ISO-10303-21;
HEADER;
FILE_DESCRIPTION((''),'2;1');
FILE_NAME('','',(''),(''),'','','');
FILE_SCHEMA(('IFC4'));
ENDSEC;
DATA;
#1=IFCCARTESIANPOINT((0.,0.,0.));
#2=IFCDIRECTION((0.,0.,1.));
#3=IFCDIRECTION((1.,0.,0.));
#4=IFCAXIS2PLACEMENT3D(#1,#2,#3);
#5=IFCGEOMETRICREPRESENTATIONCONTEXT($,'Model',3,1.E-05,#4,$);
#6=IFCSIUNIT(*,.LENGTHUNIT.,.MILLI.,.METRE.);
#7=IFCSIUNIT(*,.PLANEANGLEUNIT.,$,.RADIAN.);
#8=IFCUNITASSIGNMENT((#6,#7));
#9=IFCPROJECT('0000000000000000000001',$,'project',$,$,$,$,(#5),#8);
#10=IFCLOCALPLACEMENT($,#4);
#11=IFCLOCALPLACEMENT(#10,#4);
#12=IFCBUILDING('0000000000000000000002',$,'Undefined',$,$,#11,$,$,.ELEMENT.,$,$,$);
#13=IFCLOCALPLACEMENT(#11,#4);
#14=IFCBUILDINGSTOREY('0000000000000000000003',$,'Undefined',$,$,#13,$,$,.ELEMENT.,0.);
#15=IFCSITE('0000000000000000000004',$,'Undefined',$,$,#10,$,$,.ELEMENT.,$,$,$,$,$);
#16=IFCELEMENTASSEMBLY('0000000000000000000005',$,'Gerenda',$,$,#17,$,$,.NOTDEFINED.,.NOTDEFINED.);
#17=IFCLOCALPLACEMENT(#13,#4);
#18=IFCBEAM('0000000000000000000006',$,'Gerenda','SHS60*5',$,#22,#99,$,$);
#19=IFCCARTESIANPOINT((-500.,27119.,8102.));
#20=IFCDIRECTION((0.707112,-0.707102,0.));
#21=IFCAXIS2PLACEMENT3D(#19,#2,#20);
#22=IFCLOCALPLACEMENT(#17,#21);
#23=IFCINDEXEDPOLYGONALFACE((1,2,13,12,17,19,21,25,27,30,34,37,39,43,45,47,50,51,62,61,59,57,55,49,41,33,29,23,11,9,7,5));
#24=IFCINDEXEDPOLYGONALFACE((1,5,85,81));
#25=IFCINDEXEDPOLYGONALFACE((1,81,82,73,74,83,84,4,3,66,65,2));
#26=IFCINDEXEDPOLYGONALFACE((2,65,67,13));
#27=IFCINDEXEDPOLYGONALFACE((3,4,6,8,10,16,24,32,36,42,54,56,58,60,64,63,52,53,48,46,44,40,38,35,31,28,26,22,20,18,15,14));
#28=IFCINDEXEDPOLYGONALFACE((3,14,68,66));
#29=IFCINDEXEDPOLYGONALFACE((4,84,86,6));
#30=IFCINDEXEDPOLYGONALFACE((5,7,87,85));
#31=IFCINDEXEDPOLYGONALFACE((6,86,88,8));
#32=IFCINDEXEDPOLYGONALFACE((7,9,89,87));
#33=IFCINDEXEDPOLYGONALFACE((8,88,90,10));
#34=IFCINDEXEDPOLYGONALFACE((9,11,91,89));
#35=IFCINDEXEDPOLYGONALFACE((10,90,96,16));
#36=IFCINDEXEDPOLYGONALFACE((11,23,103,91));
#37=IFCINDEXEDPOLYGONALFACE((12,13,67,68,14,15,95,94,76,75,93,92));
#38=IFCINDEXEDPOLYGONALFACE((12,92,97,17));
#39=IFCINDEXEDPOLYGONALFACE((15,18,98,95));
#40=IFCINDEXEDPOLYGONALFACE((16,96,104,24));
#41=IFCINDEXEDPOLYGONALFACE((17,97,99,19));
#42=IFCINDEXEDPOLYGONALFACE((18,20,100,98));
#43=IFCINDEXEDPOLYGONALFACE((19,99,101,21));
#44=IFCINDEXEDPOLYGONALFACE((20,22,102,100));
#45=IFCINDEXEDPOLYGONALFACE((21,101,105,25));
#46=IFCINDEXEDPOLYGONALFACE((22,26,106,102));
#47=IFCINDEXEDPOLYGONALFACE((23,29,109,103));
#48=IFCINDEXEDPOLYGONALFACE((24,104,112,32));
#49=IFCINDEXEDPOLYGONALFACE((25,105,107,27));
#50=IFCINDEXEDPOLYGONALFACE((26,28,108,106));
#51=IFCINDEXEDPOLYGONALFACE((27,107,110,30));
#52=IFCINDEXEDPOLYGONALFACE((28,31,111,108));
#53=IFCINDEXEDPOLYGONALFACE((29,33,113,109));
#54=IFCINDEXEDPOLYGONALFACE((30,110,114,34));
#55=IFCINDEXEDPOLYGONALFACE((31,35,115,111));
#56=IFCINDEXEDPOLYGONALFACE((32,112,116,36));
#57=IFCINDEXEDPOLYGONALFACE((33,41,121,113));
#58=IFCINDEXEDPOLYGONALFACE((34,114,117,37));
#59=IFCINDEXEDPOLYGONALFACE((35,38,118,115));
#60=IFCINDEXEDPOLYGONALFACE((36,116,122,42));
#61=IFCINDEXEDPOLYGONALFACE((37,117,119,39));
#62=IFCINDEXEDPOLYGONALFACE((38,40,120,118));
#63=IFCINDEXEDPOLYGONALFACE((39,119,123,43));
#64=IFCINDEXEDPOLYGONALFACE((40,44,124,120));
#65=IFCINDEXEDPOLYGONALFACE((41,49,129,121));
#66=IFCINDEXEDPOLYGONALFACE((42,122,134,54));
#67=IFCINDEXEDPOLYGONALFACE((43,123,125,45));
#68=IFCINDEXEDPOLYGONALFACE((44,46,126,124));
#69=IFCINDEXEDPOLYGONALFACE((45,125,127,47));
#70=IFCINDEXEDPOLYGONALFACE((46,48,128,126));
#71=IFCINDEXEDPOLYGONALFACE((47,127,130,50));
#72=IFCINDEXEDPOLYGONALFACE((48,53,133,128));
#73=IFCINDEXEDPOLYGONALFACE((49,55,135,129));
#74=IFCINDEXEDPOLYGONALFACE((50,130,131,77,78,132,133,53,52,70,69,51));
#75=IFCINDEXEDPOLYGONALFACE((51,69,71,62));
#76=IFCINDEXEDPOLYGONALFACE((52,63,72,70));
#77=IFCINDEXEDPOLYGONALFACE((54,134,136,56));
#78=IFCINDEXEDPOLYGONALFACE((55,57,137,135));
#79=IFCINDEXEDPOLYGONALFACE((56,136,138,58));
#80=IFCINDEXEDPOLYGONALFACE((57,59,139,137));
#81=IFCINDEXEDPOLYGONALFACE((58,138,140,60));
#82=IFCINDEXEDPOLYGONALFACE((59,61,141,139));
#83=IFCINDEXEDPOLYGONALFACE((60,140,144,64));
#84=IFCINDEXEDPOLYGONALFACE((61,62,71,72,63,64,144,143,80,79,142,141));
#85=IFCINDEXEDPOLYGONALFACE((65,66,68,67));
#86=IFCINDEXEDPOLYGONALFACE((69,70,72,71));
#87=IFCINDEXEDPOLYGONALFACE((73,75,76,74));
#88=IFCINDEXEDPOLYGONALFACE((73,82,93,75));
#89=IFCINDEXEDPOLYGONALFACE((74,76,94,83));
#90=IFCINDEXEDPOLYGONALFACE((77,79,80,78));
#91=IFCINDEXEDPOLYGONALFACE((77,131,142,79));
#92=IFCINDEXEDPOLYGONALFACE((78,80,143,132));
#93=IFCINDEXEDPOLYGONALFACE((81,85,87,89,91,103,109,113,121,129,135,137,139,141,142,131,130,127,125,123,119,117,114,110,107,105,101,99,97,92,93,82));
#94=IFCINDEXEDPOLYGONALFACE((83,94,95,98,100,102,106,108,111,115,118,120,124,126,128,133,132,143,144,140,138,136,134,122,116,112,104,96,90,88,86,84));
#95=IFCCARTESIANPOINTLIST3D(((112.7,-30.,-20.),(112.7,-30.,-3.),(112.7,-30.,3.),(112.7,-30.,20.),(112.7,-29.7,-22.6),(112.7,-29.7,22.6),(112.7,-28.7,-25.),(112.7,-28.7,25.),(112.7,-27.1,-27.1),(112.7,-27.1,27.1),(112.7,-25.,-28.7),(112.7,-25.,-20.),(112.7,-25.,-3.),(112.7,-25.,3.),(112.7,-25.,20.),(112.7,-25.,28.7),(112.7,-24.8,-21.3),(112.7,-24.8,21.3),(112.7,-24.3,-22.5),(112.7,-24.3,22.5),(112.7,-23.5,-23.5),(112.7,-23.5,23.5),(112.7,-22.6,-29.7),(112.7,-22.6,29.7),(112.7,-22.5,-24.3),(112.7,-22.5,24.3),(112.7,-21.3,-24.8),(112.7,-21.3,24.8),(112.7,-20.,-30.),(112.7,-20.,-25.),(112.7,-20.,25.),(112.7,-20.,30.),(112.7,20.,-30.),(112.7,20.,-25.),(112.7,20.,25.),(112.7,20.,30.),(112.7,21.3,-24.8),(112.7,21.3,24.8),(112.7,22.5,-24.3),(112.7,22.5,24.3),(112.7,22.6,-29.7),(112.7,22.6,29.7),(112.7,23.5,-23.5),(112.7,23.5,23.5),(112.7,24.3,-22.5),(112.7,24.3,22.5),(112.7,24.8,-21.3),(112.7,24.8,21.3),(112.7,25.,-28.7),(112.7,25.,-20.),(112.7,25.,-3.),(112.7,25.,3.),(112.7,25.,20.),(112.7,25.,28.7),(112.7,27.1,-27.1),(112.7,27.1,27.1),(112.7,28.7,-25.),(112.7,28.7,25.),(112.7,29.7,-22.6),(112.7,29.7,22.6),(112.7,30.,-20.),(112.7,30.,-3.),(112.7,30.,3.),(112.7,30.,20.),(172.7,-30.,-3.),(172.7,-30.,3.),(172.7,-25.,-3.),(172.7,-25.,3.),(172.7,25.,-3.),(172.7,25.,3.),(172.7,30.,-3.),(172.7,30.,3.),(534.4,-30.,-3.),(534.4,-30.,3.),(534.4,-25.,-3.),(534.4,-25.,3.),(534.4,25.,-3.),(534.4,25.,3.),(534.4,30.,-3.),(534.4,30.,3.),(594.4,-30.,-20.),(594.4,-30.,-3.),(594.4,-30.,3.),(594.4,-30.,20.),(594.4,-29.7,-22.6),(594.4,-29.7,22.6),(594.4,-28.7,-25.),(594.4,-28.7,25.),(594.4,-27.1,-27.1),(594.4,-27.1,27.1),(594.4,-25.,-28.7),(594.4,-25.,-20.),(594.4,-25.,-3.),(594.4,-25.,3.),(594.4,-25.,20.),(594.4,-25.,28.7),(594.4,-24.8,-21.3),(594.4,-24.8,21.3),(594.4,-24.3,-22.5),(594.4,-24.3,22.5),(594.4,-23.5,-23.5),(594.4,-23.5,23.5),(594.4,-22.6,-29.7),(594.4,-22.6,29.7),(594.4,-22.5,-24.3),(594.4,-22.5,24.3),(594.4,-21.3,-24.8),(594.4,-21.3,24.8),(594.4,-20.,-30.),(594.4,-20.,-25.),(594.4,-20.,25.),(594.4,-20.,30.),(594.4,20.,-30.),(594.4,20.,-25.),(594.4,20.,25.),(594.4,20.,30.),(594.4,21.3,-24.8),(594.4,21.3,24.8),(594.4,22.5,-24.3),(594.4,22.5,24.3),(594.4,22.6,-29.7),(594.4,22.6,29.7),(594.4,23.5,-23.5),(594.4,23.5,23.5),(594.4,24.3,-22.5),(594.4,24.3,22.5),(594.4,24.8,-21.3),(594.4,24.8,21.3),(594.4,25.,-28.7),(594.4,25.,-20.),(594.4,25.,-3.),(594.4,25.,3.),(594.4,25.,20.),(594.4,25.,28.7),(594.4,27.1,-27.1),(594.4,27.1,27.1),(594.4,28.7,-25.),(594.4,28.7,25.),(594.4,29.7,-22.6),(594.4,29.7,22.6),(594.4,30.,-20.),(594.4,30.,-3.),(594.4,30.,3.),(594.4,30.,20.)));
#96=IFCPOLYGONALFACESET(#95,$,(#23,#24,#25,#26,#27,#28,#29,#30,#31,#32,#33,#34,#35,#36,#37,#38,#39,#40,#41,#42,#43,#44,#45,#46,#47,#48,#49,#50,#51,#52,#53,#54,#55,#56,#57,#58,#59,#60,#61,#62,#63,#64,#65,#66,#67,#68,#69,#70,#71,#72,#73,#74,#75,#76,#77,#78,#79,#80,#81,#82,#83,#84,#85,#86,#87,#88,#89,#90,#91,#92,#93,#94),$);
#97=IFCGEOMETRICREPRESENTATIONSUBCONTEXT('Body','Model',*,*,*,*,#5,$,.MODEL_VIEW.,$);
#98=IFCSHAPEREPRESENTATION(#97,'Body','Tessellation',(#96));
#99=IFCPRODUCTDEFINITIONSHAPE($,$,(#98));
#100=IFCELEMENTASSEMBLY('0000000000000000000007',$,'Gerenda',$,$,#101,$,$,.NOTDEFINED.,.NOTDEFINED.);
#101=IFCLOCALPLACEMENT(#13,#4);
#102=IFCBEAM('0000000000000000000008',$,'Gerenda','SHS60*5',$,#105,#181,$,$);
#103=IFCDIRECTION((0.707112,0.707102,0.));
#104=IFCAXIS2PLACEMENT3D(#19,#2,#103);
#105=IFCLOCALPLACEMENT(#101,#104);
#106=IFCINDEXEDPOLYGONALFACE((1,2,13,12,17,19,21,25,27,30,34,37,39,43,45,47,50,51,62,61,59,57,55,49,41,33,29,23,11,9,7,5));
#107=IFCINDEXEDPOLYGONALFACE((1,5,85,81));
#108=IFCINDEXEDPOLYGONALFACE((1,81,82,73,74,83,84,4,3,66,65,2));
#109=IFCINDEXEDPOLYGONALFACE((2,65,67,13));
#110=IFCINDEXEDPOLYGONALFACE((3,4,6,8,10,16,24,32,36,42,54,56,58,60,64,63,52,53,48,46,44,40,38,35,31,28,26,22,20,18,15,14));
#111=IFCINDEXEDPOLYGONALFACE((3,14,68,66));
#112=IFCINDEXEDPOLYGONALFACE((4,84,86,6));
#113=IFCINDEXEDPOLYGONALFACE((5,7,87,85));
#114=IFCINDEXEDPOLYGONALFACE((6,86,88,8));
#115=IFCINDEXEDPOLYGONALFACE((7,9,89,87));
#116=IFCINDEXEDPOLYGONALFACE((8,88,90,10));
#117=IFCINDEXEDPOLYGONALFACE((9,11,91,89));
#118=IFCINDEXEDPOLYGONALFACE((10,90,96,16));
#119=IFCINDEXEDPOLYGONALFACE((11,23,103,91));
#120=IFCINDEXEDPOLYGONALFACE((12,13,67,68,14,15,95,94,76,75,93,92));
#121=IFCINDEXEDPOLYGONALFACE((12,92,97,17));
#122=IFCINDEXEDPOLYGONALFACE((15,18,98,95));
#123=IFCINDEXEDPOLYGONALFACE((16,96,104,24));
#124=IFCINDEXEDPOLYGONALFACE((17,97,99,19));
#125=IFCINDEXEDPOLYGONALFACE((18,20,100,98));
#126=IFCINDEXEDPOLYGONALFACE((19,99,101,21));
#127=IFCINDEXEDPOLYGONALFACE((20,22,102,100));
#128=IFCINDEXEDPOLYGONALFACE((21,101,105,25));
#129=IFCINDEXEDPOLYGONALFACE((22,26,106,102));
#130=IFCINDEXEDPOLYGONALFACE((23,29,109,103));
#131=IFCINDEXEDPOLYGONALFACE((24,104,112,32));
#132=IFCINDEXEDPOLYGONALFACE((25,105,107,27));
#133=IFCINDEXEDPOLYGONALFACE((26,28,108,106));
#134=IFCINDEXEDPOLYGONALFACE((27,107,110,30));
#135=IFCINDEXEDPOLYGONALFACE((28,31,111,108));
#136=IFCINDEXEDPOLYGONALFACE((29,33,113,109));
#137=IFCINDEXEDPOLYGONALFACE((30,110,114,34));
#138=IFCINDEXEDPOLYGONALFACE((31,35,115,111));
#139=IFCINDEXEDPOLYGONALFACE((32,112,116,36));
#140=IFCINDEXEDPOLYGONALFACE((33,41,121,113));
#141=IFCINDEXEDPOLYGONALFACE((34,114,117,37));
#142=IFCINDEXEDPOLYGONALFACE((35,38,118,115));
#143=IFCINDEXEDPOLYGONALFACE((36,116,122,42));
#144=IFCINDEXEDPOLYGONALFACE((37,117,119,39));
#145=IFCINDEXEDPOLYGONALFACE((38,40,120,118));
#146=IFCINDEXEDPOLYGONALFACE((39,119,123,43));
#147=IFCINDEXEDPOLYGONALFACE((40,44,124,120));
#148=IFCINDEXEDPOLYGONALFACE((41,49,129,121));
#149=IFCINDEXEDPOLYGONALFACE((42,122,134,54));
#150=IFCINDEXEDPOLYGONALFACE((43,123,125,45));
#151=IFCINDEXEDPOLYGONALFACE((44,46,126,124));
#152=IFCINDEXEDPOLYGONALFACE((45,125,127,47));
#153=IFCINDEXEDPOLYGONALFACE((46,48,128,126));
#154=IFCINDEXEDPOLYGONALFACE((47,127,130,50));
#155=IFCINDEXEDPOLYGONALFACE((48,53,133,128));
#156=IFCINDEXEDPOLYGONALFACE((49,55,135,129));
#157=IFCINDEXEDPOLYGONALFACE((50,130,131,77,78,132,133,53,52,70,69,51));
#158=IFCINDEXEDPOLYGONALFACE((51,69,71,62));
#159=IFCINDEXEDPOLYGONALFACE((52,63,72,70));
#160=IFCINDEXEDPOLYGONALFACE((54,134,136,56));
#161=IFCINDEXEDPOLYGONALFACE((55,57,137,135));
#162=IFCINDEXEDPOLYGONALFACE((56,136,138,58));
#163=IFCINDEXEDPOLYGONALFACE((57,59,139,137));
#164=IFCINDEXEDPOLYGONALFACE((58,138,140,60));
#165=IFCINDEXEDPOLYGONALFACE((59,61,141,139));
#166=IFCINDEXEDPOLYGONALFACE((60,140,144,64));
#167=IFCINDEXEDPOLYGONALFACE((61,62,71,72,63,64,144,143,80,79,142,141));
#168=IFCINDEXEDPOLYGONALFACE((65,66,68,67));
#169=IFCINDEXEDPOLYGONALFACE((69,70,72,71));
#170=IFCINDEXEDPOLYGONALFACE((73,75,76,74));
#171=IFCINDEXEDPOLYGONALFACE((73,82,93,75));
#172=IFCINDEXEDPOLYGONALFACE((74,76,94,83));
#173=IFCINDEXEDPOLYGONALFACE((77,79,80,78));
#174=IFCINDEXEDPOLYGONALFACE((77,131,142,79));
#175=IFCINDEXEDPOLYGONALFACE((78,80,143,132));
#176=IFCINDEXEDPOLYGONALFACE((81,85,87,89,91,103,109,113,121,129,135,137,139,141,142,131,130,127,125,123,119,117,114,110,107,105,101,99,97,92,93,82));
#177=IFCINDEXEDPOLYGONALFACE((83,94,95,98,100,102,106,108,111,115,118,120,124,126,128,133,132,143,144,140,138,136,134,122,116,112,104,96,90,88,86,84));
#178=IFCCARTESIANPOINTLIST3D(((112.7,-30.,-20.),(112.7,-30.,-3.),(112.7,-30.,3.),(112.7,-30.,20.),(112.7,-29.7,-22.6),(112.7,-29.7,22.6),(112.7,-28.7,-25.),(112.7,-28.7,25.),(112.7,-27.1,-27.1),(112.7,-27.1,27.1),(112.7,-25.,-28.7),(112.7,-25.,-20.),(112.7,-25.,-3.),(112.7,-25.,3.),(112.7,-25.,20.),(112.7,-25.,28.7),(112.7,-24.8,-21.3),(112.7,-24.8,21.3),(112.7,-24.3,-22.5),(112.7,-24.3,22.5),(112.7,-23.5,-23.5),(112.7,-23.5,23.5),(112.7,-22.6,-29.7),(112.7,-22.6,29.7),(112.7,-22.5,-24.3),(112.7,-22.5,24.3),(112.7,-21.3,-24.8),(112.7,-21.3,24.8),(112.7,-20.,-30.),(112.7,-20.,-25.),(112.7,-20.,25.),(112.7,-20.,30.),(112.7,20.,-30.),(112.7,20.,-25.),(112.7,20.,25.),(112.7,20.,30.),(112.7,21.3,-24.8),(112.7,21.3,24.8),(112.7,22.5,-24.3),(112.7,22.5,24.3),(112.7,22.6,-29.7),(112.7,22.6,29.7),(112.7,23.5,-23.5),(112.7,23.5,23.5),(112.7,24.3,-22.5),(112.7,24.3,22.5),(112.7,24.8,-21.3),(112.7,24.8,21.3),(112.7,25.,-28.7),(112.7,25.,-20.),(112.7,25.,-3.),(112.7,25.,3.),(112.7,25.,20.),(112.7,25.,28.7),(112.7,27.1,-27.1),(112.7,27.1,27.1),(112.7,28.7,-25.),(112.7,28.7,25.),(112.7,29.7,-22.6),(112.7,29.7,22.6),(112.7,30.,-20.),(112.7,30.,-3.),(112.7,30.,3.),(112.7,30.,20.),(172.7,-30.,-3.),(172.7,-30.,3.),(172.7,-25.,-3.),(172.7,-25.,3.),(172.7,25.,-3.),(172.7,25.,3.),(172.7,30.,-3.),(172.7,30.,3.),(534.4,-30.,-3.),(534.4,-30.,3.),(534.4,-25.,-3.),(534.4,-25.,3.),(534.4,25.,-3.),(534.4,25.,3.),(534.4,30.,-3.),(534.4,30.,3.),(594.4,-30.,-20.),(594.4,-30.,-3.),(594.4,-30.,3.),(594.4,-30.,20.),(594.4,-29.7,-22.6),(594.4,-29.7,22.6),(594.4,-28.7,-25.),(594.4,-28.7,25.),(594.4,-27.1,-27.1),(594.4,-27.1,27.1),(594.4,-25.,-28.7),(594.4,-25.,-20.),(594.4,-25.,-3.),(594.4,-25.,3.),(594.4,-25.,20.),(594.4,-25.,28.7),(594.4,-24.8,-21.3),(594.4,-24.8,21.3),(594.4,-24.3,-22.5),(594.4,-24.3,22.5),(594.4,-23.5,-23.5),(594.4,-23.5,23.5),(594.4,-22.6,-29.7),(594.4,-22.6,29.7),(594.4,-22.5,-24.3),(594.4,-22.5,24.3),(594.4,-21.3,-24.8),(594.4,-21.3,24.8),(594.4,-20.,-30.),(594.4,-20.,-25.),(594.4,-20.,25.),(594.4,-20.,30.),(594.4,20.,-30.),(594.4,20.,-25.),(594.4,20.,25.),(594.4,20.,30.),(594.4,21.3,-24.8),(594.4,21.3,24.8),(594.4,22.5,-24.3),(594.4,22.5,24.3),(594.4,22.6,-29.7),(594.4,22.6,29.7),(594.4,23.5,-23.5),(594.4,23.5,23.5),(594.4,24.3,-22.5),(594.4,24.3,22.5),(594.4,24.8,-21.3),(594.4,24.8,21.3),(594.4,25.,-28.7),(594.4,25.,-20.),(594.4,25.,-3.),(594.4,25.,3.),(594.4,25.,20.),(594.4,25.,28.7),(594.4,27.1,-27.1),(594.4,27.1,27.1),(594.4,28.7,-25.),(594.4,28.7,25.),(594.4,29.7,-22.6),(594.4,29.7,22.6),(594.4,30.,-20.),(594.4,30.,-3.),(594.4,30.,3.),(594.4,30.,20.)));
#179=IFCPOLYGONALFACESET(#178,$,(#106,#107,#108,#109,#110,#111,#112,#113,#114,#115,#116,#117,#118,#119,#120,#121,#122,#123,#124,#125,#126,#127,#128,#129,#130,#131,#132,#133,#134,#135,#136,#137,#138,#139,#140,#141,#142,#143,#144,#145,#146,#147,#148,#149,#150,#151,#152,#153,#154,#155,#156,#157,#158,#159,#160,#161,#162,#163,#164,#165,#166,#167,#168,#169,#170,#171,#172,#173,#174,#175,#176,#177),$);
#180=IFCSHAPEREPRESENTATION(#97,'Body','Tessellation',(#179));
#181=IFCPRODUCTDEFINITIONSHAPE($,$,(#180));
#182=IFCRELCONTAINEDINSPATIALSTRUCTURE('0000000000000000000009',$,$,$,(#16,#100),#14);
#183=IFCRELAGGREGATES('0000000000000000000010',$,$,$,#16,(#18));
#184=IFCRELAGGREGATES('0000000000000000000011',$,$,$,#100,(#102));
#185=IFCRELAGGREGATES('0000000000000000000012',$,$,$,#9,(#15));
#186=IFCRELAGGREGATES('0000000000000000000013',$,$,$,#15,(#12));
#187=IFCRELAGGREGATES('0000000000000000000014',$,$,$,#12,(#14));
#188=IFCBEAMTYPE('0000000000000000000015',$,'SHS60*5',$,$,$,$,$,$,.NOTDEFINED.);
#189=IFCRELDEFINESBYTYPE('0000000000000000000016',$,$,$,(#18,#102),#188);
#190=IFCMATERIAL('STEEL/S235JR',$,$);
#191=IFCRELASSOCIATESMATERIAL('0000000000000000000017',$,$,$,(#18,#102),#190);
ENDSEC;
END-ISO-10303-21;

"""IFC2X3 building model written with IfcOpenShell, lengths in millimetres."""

from ifc_helpers import new_model, si_unit, frame, origin_with_axes, origin_2d_with_axis, place, context, subcontext, project, spatial, rectangle, hollow_rectangle, extrude, boolean, halfspace, material, type_object, element, aggregate, save


model = new_model("IFC2X3")

# Units and contexts
model_context = context("Model", 3, precision=1e-05, world=origin_with_axes())
body_context = subcontext(model_context, "Body", "Model", "MODEL_VIEW")
ifc_project = project(units=[si_unit("LENGTHUNIT", "METRE", prefix="MILLI"), si_unit("PLANEANGLEUNIT", "RADIAN")], contexts=[model_context])

# Site, building, storey
site_placement = place(None, origin_with_axes())
site = spatial("IfcSite", under=ifc_project, at=site_placement, Name="Undefined", CompositionType="ELEMENT")
building_placement = place(site_placement, origin_with_axes())
building = spatial("IfcBuilding", under=site, at=building_placement, Name="Undefined", CompositionType="ELEMENT")
storey_placement = place(building_placement, origin_with_axes())
storey = spatial("IfcBuildingStorey", under=building, at=storey_placement, Name="Undefined", CompositionType="ELEMENT", Elevation=0.0)

# Element assemblies, beams
ifc_material_1 = material(Name="STEEL/S235JR")
beam_type_1 = type_object("IfcBeamType", Name="SHS60*5", PredefinedType="NOTDEFINED")
assembly_1_placement = place(storey_placement, origin_with_axes())
assembly_1 = element("IfcElementAssembly", 1, at=assembly_1_placement, inside=storey, Name="Gerenda", AssemblyPlace="NOTDEFINED", PredefinedType="NOTDEFINED")
beam_1_placement = place(assembly_1_placement, frame((-500.0, 27119.0, 8102.0), z_axis=(0.0, 0.0, 1.0), x_axis=(0.707112, -0.707102, 0.0)))
beam_1 = element("IfcBeam", 2, at=beam_1_placement, type_object=beam_type_1, material=ifc_material_1, Name="Gerenda", Description="SHS60*5", context=body_context, shape_type="CSG", body=[
    boolean("DIFFERENCE", boolean("DIFFERENCE", boolean("DIFFERENCE", boolean("DIFFERENCE", extrude(hollow_rectangle(XDim=60.0, YDim=60.0, WallThickness=5.0, InnerFilletRadius=5.0, OuterFilletRadius=10.0, at=origin_2d_with_axis()), frame((707.1, 0.0, 0.0), z_axis=(-1.0, 0.0, 0.0), x_axis=(0.0, -1.0, 0.0)), (0.0, 0.0, 1.0), 707.1), extrude(rectangle(XDim=6.0, YDim=64.0, at=origin_2d_with_axis()), frame((172.7, 0.0, 0.0), z_axis=(-1.0, 0.0, 0.0), x_axis=(0.0, 0.0, -1.0)), (0.0, 0.0, 1.0), 62.0)), extrude(rectangle(XDim=6.0, YDim=64.0, at=origin_2d_with_axis()), frame((534.4, 0.0, 0.0), z_axis=(1.0, 0.0, 0.0), x_axis=(0.0, 0.0, -1.0)), (0.0, 0.0, 1.0), 62.0)), halfspace(frame((594.4, 0.0, -9.0), z_axis=(-1.0, 0.0, 0.0), x_axis=(0.0, 1.0, 0.0)), True)), halfspace(frame((112.7, 0.0, -9.0), z_axis=(1.0, 0.0, 0.0), x_axis=(0.0, -1.0, 0.0)), True)),
])
aggregate(assembly_1, [beam_1])
assembly_2_placement = place(storey_placement, origin_with_axes())
assembly_2 = element("IfcElementAssembly", 3, at=assembly_2_placement, inside=storey, Name="Gerenda", AssemblyPlace="NOTDEFINED", PredefinedType="NOTDEFINED")
beam_2_placement = place(assembly_2_placement, frame((-500.0, 27119.0, 8102.0), z_axis=(0.0, 0.0, 1.0), x_axis=(0.707112, 0.707102, 0.0)))
beam_2 = element("IfcBeam", 4, at=beam_2_placement, type_object=beam_type_1, material=ifc_material_1, Name="Gerenda", Description="SHS60*5", context=body_context, shape_type="CSG", body=[
    boolean("DIFFERENCE", boolean("DIFFERENCE", boolean("DIFFERENCE", boolean("DIFFERENCE", extrude(hollow_rectangle(XDim=60.0, YDim=60.0, WallThickness=5.0, InnerFilletRadius=5.0, OuterFilletRadius=10.0, at=origin_2d_with_axis()), frame((707.1, 0.0, 0.0), z_axis=(-1.0, 0.0, 0.0), x_axis=(0.0, -1.0, 0.0)), (0.0, 0.0, 1.0), 707.1), extrude(rectangle(XDim=6.0, YDim=64.0, at=origin_2d_with_axis()), frame((172.7, 0.0, 0.0), z_axis=(-1.0, 0.0, 0.0), x_axis=(0.0, 0.0, -1.0)), (0.0, 0.0, 1.0), 62.0)), extrude(rectangle(XDim=6.0, YDim=64.0, at=origin_2d_with_axis()), frame((534.4, 0.0, 0.0), z_axis=(1.0, 0.0, 0.0), x_axis=(0.0, 0.0, -1.0)), (0.0, 0.0, 1.0), 62.0)), halfspace(frame((594.4, 0.0, -9.0), z_axis=(-1.0, 0.0, 0.0), x_axis=(0.0, 1.0, 0.0)), True)), halfspace(frame((112.7, 0.0, -9.0), z_axis=(1.0, 0.0, 0.0), x_axis=(0.0, -1.0, 0.0)), True)),
])

aggregate(assembly_2, [beam_2])

save(model, "model.ifc")
